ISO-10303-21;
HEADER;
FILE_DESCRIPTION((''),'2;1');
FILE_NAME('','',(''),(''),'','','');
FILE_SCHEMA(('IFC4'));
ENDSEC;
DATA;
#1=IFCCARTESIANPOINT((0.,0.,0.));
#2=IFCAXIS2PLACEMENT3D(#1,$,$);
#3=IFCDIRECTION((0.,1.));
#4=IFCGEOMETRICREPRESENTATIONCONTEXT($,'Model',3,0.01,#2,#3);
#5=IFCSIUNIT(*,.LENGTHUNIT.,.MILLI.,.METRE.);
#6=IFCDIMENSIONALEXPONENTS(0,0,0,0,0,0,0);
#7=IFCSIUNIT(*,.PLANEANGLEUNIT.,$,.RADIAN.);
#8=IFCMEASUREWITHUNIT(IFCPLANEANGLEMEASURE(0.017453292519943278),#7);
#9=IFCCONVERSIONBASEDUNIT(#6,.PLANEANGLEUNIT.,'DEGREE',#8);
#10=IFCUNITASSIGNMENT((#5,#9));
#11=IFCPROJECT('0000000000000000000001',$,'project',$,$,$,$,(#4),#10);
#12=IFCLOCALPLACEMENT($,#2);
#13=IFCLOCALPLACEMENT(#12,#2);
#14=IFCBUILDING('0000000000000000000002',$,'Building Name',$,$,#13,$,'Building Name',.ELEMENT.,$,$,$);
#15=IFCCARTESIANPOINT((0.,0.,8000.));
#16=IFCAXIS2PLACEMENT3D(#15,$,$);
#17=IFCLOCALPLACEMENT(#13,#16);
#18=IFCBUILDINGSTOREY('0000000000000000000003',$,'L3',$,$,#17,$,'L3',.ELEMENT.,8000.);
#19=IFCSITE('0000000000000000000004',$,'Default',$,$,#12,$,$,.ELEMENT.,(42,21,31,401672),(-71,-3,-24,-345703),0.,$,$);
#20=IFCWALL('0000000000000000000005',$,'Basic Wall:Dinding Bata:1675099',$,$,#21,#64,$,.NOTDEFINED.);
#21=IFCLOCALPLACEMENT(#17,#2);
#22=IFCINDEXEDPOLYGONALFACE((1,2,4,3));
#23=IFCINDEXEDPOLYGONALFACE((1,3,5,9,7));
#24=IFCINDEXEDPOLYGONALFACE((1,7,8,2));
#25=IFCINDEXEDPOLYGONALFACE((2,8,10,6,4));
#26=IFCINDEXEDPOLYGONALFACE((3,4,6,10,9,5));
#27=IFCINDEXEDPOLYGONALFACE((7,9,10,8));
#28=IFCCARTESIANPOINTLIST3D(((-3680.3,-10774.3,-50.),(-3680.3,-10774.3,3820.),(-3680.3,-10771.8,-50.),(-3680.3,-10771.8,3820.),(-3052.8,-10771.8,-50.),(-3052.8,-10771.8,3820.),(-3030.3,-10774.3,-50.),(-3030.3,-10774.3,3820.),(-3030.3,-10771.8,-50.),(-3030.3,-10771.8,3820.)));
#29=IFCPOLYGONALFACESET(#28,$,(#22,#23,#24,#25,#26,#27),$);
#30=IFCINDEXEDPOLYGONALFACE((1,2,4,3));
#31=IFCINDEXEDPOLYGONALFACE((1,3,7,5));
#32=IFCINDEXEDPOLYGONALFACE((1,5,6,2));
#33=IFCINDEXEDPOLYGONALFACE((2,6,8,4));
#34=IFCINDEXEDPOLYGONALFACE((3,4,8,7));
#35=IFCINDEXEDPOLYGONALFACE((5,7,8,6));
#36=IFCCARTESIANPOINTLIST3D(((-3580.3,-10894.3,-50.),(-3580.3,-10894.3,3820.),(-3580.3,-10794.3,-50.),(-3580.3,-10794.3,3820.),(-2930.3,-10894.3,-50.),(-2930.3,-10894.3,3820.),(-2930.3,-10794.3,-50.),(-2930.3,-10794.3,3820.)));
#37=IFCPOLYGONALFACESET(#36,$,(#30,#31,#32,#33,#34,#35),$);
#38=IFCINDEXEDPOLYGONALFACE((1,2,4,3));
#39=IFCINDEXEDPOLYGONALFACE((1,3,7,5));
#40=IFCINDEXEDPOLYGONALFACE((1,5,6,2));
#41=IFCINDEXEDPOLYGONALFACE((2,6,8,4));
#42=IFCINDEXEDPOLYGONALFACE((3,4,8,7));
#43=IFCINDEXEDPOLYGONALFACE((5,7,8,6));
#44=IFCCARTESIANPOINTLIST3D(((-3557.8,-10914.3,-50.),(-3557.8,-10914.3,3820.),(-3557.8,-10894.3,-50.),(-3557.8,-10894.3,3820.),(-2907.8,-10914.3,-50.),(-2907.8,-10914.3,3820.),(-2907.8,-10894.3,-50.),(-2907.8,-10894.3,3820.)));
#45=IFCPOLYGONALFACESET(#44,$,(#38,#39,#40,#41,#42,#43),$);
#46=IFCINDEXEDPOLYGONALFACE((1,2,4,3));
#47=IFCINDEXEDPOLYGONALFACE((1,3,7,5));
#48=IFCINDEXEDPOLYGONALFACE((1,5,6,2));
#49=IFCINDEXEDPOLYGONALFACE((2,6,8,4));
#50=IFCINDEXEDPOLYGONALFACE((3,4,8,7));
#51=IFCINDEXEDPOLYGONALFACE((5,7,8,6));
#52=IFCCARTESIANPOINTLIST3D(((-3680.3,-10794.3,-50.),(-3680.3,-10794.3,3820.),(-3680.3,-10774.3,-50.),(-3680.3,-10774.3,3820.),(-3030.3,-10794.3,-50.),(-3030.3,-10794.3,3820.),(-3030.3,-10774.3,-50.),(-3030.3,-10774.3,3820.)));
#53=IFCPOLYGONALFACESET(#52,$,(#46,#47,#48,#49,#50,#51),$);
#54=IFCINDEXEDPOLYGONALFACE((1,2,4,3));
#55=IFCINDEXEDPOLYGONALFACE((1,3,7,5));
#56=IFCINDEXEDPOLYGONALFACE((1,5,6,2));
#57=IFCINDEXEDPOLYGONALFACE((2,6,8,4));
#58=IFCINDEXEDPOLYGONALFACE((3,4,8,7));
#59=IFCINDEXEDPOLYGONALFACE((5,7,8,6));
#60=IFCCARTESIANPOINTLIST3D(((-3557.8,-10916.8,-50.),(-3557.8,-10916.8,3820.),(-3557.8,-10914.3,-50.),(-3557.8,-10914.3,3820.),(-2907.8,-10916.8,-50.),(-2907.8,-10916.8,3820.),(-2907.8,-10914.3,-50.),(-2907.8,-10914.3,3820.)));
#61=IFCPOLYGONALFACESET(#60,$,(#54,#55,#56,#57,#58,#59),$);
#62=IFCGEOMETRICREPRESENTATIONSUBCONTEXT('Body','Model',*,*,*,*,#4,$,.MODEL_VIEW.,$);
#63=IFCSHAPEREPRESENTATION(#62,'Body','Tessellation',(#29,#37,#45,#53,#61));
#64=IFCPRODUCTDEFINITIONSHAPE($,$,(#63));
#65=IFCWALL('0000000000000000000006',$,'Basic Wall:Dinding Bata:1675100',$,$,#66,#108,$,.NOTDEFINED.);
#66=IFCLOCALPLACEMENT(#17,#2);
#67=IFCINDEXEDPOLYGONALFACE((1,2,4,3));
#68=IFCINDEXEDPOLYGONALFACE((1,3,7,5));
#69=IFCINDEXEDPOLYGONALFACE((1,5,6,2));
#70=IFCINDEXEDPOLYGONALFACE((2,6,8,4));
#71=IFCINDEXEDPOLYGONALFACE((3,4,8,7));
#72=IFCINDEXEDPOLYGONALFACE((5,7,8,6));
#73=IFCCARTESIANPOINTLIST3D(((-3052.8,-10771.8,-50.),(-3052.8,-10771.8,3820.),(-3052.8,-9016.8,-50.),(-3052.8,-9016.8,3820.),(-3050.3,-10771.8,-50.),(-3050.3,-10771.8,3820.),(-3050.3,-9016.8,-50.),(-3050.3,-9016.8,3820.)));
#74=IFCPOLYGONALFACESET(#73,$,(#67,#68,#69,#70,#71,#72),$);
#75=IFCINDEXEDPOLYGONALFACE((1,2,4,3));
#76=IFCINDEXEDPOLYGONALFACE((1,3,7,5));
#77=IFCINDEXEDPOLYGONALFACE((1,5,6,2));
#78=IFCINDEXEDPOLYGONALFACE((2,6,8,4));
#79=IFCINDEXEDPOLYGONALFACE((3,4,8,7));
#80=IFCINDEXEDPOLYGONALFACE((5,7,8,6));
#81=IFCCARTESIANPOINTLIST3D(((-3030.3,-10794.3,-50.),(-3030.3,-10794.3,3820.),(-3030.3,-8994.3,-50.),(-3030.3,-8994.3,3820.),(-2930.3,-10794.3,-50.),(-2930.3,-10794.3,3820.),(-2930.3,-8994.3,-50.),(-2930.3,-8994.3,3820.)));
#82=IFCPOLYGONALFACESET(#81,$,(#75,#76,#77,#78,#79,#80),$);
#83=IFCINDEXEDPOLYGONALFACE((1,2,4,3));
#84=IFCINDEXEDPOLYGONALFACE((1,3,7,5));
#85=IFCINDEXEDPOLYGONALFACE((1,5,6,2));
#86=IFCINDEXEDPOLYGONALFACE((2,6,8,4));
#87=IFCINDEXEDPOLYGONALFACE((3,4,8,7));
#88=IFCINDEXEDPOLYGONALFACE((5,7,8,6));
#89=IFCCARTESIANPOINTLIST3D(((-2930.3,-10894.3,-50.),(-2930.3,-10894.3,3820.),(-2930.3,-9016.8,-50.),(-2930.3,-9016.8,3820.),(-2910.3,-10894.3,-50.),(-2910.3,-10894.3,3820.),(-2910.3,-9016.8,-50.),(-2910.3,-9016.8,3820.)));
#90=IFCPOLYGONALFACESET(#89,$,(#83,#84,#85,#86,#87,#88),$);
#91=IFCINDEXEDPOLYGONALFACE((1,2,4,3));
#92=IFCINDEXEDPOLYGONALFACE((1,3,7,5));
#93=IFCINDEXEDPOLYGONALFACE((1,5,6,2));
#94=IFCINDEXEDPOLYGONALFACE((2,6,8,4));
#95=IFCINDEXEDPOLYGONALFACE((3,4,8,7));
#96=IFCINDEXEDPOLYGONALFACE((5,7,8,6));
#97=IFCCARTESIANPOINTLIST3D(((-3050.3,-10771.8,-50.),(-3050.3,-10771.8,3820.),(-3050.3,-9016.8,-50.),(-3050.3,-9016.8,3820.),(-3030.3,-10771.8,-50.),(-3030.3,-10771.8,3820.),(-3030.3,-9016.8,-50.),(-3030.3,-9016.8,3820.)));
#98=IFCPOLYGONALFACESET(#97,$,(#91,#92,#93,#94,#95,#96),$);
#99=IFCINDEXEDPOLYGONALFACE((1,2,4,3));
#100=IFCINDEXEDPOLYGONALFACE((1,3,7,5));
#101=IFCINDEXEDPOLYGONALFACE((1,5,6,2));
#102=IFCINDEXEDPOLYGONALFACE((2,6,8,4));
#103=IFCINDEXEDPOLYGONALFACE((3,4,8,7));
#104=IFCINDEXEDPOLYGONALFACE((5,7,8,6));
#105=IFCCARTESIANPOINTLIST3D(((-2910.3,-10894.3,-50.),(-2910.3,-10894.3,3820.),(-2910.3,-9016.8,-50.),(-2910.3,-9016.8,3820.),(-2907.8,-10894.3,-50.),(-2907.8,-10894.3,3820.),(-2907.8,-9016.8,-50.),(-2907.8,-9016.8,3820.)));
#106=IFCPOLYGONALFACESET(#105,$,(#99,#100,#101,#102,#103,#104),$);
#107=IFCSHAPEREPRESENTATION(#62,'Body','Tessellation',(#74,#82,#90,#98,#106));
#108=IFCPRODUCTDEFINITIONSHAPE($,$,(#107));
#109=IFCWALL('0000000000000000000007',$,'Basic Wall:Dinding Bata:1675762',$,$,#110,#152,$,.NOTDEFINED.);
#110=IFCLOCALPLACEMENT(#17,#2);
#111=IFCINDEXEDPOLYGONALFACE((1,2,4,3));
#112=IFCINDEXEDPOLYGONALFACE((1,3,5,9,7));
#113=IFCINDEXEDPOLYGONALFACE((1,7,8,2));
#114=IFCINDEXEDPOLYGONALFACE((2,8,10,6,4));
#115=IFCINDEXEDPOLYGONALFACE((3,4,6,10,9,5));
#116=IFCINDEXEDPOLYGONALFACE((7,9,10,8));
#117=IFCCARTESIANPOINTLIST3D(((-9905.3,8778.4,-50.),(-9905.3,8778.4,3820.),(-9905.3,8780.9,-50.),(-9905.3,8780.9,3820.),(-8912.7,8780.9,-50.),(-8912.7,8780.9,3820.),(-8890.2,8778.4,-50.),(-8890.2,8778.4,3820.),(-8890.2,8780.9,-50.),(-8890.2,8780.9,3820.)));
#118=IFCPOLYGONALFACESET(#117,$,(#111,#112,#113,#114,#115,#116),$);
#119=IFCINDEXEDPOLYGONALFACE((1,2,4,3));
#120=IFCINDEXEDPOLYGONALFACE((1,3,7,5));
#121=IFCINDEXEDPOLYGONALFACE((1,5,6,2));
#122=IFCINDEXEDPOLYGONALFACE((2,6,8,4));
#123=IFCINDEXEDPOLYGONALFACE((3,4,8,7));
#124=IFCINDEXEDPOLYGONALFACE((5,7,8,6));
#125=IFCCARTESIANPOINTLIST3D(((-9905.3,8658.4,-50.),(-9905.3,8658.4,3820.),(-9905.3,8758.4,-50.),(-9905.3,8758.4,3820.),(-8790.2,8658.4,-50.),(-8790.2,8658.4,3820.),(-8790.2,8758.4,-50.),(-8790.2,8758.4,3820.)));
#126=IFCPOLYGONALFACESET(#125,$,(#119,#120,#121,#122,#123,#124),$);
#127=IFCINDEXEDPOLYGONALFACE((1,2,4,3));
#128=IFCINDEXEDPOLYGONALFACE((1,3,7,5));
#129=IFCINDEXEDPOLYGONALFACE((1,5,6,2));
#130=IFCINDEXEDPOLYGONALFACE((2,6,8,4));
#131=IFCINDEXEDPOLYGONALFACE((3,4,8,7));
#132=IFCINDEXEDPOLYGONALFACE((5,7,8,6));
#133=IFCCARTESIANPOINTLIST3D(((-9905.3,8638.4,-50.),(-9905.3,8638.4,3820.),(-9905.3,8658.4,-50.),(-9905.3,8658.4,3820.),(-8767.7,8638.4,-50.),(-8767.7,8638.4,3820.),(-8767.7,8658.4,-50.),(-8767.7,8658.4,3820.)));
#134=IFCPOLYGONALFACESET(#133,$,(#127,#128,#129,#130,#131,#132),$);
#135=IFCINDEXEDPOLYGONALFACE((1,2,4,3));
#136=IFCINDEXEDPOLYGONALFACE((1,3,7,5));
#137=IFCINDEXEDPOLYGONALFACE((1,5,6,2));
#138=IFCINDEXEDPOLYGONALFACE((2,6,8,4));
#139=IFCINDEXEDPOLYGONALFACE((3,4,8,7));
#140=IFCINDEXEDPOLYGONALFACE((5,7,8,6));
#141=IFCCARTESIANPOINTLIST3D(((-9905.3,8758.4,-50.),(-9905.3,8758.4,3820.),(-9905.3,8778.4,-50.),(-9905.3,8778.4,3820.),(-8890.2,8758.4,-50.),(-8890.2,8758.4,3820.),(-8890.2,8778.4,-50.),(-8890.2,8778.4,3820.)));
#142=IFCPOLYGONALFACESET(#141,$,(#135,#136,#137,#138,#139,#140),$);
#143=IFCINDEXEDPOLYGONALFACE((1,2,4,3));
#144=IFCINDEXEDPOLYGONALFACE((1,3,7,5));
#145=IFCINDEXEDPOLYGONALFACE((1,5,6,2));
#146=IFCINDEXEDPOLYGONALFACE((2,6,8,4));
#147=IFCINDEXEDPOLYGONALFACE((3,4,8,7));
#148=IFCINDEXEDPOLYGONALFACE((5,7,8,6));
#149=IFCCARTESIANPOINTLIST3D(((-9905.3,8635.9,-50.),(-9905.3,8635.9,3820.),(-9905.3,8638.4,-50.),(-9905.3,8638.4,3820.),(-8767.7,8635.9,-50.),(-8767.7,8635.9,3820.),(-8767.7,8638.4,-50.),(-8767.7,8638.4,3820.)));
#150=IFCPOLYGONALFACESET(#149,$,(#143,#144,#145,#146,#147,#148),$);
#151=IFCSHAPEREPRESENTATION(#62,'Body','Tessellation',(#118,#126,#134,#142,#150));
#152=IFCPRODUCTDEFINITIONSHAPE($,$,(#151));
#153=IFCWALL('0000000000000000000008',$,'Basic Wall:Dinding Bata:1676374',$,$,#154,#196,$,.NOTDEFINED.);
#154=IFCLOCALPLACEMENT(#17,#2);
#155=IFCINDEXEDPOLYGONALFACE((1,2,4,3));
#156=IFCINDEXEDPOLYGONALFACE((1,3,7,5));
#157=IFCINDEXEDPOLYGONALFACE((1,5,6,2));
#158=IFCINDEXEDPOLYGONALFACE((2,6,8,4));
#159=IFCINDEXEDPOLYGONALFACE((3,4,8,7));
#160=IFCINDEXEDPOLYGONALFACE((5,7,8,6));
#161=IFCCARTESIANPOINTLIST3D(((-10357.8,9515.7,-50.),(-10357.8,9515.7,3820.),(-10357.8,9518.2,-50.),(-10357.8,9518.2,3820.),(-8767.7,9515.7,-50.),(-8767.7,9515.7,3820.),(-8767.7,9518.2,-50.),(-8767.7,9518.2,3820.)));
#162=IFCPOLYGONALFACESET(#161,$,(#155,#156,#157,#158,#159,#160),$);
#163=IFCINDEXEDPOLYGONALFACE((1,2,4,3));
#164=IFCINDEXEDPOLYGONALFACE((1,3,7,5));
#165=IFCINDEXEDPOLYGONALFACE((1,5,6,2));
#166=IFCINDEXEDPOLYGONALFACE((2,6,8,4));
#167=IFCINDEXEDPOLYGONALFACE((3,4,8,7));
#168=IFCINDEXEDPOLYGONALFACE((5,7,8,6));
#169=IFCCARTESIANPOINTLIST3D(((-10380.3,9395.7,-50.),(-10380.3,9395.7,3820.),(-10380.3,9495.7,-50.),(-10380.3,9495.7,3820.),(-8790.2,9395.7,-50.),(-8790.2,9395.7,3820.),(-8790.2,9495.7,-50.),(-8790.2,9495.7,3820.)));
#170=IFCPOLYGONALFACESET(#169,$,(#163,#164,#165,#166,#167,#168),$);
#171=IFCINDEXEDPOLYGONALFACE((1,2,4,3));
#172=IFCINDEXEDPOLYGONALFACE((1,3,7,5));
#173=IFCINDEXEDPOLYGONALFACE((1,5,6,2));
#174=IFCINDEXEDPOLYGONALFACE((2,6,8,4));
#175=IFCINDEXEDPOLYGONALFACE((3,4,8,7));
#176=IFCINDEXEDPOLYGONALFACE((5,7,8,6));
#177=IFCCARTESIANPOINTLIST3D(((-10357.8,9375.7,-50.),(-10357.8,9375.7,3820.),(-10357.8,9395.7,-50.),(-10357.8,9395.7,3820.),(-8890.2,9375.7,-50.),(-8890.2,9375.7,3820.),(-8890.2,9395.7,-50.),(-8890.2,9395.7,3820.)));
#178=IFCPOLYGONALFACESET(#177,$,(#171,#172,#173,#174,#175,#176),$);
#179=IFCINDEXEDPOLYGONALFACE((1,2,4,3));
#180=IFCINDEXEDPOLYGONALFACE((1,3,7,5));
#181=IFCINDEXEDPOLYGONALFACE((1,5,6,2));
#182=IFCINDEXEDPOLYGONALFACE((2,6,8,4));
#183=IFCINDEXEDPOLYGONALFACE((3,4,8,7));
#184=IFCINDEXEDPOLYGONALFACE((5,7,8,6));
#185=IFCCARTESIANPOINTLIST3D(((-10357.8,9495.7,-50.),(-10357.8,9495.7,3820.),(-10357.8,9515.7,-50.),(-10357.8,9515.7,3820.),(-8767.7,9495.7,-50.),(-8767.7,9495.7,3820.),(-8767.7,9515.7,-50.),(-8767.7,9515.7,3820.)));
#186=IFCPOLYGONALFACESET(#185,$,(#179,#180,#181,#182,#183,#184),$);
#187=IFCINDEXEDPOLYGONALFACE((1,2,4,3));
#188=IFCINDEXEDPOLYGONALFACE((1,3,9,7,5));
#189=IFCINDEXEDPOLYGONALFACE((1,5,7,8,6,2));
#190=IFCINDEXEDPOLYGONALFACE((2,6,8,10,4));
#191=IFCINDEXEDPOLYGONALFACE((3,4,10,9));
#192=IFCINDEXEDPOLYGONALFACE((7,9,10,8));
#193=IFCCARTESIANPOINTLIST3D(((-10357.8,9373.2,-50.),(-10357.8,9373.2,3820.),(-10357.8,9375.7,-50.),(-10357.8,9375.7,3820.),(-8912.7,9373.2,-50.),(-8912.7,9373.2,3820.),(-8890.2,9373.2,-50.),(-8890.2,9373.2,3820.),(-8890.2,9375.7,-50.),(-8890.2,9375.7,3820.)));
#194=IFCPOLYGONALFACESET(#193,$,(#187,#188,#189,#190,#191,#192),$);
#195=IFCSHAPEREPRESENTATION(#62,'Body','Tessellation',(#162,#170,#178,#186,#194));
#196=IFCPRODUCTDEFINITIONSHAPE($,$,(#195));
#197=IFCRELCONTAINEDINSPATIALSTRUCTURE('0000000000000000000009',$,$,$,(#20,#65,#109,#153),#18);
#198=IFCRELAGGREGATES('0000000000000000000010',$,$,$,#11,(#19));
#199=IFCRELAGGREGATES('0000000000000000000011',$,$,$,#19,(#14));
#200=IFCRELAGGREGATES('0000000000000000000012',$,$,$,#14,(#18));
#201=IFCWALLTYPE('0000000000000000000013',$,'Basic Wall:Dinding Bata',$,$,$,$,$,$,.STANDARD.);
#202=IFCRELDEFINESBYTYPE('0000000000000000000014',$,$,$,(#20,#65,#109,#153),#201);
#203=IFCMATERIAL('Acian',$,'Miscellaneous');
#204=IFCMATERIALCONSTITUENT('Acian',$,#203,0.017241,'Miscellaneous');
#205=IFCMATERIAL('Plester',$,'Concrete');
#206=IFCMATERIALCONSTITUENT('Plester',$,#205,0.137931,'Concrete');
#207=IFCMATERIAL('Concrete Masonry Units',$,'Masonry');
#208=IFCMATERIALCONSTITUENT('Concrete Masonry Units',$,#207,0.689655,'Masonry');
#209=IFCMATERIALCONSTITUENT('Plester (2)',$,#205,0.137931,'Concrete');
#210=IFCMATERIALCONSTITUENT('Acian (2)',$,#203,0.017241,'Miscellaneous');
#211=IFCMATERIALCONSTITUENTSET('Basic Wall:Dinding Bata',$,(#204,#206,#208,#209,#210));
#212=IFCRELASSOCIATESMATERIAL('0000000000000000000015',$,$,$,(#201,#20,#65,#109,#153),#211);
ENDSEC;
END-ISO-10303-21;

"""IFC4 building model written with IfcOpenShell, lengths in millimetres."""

from ifc_helpers import new_model, entity, si_unit, converted_unit, direction, frame, origin, place, context, subcontext, project, spatial, indexed_curve, outline, extrude, material, constituent, constituent_set, type_object, element, save


model = new_model("IFC4")

# Units and contexts
model_context = context("Model", 3, precision=0.01, world=origin(), true_north=direction((0.0, 1.0)))
body_context = subcontext(model_context, "Body", "Model", "MODEL_VIEW")
ifc_project = project(units=[si_unit("LENGTHUNIT", "METRE", prefix="MILLI"), converted_unit("PLANEANGLEUNIT", "DEGREE", entity("IfcPlaneAngleMeasure", 0.017453292519943278), si_unit("PLANEANGLEUNIT", "RADIAN"), dimensions=[0, 0, 0, 0, 0, 0, 0])], contexts=[model_context])

# Site, building, storey
site_placement = place(None, origin())
site = spatial("IfcSite", under=ifc_project, at=site_placement, Name="Default", CompositionType="ELEMENT", RefLatitude=(42, 21, 31, 401672), RefLongitude=(-71, -3, -24, -345703), RefElevation=0.0)
building_placement = place(site_placement, origin())
building = spatial("IfcBuilding", under=site, at=building_placement, Name="Building Name", LongName="Building Name", CompositionType="ELEMENT")
storey_placement = place(building_placement, frame((0.0, 0.0, 8000.0)))
storey = spatial("IfcBuildingStorey", under=building, at=storey_placement, Name="L3", LongName="L3", CompositionType="ELEMENT", Elevation=8000.0)

# Walls
ifc_material_1 = material(Name="Acian", Category="Miscellaneous")
ifc_constituent_1 = constituent(ifc_material_1, Name="Acian", Category="Miscellaneous", fraction=0.017241)
ifc_material_2 = material(Name="Plester", Category="Concrete")
ifc_constituent_2 = constituent(ifc_material_2, Name="Plester", Category="Concrete", fraction=0.137931)
ifc_material_3 = material(Name="Concrete Masonry Units", Category="Masonry")
ifc_constituent_3 = constituent(ifc_material_3, Name="Concrete Masonry Units", Category="Masonry", fraction=0.689655)
ifc_constituent_4 = constituent(ifc_material_2, Name="Plester (2)", Category="Concrete", fraction=0.137931)
ifc_constituent_5 = constituent(ifc_material_1, Name="Acian (2)", Category="Miscellaneous", fraction=0.017241)
ifc_constituent_set = constituent_set(constituents=[ifc_constituent_1, ifc_constituent_2, ifc_constituent_3, ifc_constituent_4, ifc_constituent_5], Name="Basic Wall:Dinding Bata")
wall_type = type_object("IfcWallType", Name="Basic Wall:Dinding Bata", PredefinedType="STANDARD", material=ifc_constituent_set)
wall_1_placement = place(storey_placement, frame((-3557.8, -10844.3, -50.0)))
element("IfcWall", 1, at=wall_1_placement, inside=storey, type_object=wall_type, material=ifc_constituent_set, Name="Basic Wall:Dinding Bata:1675099", PredefinedType="NOTDEFINED", context=body_context, shape_type="SweptSolid", body=[
    extrude(outline(indexed_curve([(-242.0, -1.0), (385.5, -1.0), (385.5, 1.5), (-264.5, 1.5), (-264.5, -1.0), (-242.0, -1.0)], self_intersect=False)), frame((263.0, 71.5, 0.0), z_axis=(0.0, 0.0, 1.0), x_axis=(-1.0, 0.0, 0.0)), (0.0, 0.0, 1.0), 3870.0),
    extrude(outline(indexed_curve([(-325.0, -50.0), (325.0, -50.0), (325.0, 50.0), (-325.0, 50.0), (-325.0, -50.0)], self_intersect=False)), frame((302.5, 0.0, 0.0)), (0.0, 0.0, 1.0), 3870.0),
    extrude(outline(indexed_curve([(-325.0, -10.0), (325.0, -10.0), (325.0, 10.0), (-325.0, 10.0), (-325.0, -10.0)], self_intersect=False)), frame((325.0, -60.0, 0.0)), (0.0, 0.0, 1.0), 3870.0),
    extrude(outline(indexed_curve([(-325.0, -10.0), (325.0, -10.0), (325.0, 10.0), (-325.0, 10.0), (-325.0, -10.0)], self_intersect=False)), frame((202.5, 60.0, 0.0)), (0.0, 0.0, 1.0), 3870.0),
    extrude(outline(indexed_curve([(-1.3, -325.0), (1.2, -325.0), (1.2, 325.0), (-1.2, 325.0), (-1.3, -325.0)], self_intersect=False)), frame((325.0, -71.2, 0.0), z_axis=(0.0, 0.0, 1.0), x_axis=(0.0, 1.0, 0.0)), (0.0, 0.0, 1.0), 3870.0),
])
wall_2_placement = place(storey_placement, frame((-2980.3, -10771.8, -50.0), z_axis=(0.0, 0.0, 1.0), x_axis=(0.0, 1.0, 0.0)))
element("IfcWall", 2, at=wall_2_placement, inside=storey, type_object=wall_type, material=ifc_constituent_set, Name="Basic Wall:Dinding Bata:1675100", PredefinedType="NOTDEFINED", context=body_context, shape_type="SweptSolid", body=[
    extrude(outline(indexed_curve([(-1.3, -877.5), (1.2, -877.5), (1.3, 877.5), (-1.2, 877.5), (-1.3, -877.5)], self_intersect=False)), frame((877.5, 71.2, 0.0), z_axis=(0.0, 0.0, 1.0), x_axis=(0.0, -1.0, 0.0)), (0.0, 0.0, 1.0), 3870.0),
    extrude(outline(indexed_curve([(-900.0, -50.0), (900.0, -50.0), (900.0, 50.0), (-900.0, 50.0), (-900.0, -50.0)], self_intersect=False)), frame((877.5, 0.0, 0.0)), (0.0, 0.0, 1.0), 3870.0),
    extrude(outline(indexed_curve([(-938.8, -10.0), (938.8, -10.0), (938.8, 10.0), (-938.8, 10.0), (-938.8, -10.0)], self_intersect=False)), frame((816.3, -60.0, 0.0)), (0.0, 0.0, 1.0), 3870.0),
    extrude(outline(indexed_curve([(-877.5, -10.0), (877.5, -10.0), (877.5, 10.0), (-877.5, 10.0), (-877.5, -10.0)], self_intersect=False)), frame((877.5, 60.0, 0.0)), (0.0, 0.0, 1.0), 3870.0),
    extrude(outline(indexed_curve([(-1.3, -938.8), (1.2, -938.8), (1.3, 938.8), (-1.2, 938.8), (-1.3, -938.8)], self_intersect=False)), frame((816.3, -71.3, 0.0), z_axis=(0.0, 0.0, 1.0), x_axis=(0.0, 1.0, 0.0)), (0.0, 0.0, 1.0), 3870.0),
])
wall_3_placement = place(storey_placement, frame((-9905.3, 8708.4, -50.0)))
element("IfcWall", 3, at=wall_3_placement, inside=storey, type_object=wall_type, material=ifc_constituent_set, Name="Basic Wall:Dinding Bata:1675762", PredefinedType="NOTDEFINED", context=body_context, shape_type="SweptSolid", body=[
    extrude(outline(indexed_curve([(-388.0, -1.0), (604.5, -1.0), (604.5, 1.5), (-410.5, 1.5), (-410.5, -1.0), (-388.0, -1.0)], self_intersect=False)), frame((604.5, 71.5, 0.0), z_axis=(0.0, 0.0, 1.0), x_axis=(-1.0, 0.0, 0.0)), (0.0, 0.0, 1.0), 3870.0),
    extrude(outline(indexed_curve([(-557.5, -50.0), (557.5, -50.0), (557.5, 50.0), (-557.5, 50.0), (-557.5, -50.0)], self_intersect=False)), frame((557.5, 0.0, 0.0)), (0.0, 0.0, 1.0), 3870.0),
    extrude(outline(indexed_curve([(-568.8, -10.0), (568.8, -10.0), (568.8, 10.0), (-568.8, 10.0), (-568.8, -10.0)], self_intersect=False)), frame((568.8, -60.0, 0.0)), (0.0, 0.0, 1.0), 3870.0),
    extrude(outline(indexed_curve([(-507.5, -10.0), (507.5, -10.0), (507.5, 10.0), (-507.5, 10.0), (-507.5, -10.0)], self_intersect=False)), frame((507.5, 60.0, 0.0)), (0.0, 0.0, 1.0), 3870.0),
    extrude(outline(indexed_curve([(-1.3, -568.8), (1.2, -568.8), (1.3, 568.8), (-1.2, 568.8), (-1.3, -568.8)], self_intersect=False)), frame((568.8, -71.3, 0.0), z_axis=(0.0, 0.0, 1.0), x_axis=(0.0, 1.0, 0.0)), (0.0, 0.0, 1.0), 3870.0),
])
wall_4_placement = place(storey_placement, frame((-10357.8, 9445.7, -50.0)))
element("IfcWall", 4, at=wall_4_placement, inside=storey, type_object=wall_type, material=ifc_constituent_set, Name="Basic Wall:Dinding Bata:1676374", PredefinedType="NOTDEFINED", context=body_context, shape_type="SweptSolid", body=[
    extrude(outline(indexed_curve([(-1.3, -795.0), (1.2, -795.0), (1.3, 795.0), (-1.2, 795.0), (-1.3, -795.0)], self_intersect=False)), frame((795.0, 71.3, 0.0), z_axis=(0.0, 0.0, 1.0), x_axis=(0.0, -1.0, 0.0)), (0.0, 0.0, 1.0), 3870.0),
    extrude(outline(indexed_curve([(-795.0, -50.0), (795.0, -50.0), (795.0, 50.0), (-795.0, 50.0), (-795.0, -50.0)], self_intersect=False)), frame((772.5, 0.0, 0.0)), (0.0, 0.0, 1.0), 3870.0),
    extrude(outline(indexed_curve([(-733.8, -10.0), (733.8, -10.0), (733.8, 10.0), (-733.8, 10.0), (-733.8, -10.0)], self_intersect=False)), frame((733.8, -60.0, 0.0)), (0.0, 0.0, 1.0), 3870.0),
    extrude(outline(indexed_curve([(-795.0, -10.0), (795.0, -10.0), (795.0, 10.0), (-795.0, 10.0), (-795.0, -10.0)], self_intersect=False)), frame((795.0, 60.0, 0.0)), (0.0, 0.0, 1.0), 3870.0),
    extrude(outline(indexed_curve([(569.0, -1.0), (591.5, -1.0), (591.5, 1.5), (-876.0, 1.5), (-876.0, -1.0), (569.0, -1.0)], self_intersect=False)), frame((876.0, -71.5, 0.0)), (0.0, 0.0, 1.0), 3870.0),
])

save(model, "model.ifc")
